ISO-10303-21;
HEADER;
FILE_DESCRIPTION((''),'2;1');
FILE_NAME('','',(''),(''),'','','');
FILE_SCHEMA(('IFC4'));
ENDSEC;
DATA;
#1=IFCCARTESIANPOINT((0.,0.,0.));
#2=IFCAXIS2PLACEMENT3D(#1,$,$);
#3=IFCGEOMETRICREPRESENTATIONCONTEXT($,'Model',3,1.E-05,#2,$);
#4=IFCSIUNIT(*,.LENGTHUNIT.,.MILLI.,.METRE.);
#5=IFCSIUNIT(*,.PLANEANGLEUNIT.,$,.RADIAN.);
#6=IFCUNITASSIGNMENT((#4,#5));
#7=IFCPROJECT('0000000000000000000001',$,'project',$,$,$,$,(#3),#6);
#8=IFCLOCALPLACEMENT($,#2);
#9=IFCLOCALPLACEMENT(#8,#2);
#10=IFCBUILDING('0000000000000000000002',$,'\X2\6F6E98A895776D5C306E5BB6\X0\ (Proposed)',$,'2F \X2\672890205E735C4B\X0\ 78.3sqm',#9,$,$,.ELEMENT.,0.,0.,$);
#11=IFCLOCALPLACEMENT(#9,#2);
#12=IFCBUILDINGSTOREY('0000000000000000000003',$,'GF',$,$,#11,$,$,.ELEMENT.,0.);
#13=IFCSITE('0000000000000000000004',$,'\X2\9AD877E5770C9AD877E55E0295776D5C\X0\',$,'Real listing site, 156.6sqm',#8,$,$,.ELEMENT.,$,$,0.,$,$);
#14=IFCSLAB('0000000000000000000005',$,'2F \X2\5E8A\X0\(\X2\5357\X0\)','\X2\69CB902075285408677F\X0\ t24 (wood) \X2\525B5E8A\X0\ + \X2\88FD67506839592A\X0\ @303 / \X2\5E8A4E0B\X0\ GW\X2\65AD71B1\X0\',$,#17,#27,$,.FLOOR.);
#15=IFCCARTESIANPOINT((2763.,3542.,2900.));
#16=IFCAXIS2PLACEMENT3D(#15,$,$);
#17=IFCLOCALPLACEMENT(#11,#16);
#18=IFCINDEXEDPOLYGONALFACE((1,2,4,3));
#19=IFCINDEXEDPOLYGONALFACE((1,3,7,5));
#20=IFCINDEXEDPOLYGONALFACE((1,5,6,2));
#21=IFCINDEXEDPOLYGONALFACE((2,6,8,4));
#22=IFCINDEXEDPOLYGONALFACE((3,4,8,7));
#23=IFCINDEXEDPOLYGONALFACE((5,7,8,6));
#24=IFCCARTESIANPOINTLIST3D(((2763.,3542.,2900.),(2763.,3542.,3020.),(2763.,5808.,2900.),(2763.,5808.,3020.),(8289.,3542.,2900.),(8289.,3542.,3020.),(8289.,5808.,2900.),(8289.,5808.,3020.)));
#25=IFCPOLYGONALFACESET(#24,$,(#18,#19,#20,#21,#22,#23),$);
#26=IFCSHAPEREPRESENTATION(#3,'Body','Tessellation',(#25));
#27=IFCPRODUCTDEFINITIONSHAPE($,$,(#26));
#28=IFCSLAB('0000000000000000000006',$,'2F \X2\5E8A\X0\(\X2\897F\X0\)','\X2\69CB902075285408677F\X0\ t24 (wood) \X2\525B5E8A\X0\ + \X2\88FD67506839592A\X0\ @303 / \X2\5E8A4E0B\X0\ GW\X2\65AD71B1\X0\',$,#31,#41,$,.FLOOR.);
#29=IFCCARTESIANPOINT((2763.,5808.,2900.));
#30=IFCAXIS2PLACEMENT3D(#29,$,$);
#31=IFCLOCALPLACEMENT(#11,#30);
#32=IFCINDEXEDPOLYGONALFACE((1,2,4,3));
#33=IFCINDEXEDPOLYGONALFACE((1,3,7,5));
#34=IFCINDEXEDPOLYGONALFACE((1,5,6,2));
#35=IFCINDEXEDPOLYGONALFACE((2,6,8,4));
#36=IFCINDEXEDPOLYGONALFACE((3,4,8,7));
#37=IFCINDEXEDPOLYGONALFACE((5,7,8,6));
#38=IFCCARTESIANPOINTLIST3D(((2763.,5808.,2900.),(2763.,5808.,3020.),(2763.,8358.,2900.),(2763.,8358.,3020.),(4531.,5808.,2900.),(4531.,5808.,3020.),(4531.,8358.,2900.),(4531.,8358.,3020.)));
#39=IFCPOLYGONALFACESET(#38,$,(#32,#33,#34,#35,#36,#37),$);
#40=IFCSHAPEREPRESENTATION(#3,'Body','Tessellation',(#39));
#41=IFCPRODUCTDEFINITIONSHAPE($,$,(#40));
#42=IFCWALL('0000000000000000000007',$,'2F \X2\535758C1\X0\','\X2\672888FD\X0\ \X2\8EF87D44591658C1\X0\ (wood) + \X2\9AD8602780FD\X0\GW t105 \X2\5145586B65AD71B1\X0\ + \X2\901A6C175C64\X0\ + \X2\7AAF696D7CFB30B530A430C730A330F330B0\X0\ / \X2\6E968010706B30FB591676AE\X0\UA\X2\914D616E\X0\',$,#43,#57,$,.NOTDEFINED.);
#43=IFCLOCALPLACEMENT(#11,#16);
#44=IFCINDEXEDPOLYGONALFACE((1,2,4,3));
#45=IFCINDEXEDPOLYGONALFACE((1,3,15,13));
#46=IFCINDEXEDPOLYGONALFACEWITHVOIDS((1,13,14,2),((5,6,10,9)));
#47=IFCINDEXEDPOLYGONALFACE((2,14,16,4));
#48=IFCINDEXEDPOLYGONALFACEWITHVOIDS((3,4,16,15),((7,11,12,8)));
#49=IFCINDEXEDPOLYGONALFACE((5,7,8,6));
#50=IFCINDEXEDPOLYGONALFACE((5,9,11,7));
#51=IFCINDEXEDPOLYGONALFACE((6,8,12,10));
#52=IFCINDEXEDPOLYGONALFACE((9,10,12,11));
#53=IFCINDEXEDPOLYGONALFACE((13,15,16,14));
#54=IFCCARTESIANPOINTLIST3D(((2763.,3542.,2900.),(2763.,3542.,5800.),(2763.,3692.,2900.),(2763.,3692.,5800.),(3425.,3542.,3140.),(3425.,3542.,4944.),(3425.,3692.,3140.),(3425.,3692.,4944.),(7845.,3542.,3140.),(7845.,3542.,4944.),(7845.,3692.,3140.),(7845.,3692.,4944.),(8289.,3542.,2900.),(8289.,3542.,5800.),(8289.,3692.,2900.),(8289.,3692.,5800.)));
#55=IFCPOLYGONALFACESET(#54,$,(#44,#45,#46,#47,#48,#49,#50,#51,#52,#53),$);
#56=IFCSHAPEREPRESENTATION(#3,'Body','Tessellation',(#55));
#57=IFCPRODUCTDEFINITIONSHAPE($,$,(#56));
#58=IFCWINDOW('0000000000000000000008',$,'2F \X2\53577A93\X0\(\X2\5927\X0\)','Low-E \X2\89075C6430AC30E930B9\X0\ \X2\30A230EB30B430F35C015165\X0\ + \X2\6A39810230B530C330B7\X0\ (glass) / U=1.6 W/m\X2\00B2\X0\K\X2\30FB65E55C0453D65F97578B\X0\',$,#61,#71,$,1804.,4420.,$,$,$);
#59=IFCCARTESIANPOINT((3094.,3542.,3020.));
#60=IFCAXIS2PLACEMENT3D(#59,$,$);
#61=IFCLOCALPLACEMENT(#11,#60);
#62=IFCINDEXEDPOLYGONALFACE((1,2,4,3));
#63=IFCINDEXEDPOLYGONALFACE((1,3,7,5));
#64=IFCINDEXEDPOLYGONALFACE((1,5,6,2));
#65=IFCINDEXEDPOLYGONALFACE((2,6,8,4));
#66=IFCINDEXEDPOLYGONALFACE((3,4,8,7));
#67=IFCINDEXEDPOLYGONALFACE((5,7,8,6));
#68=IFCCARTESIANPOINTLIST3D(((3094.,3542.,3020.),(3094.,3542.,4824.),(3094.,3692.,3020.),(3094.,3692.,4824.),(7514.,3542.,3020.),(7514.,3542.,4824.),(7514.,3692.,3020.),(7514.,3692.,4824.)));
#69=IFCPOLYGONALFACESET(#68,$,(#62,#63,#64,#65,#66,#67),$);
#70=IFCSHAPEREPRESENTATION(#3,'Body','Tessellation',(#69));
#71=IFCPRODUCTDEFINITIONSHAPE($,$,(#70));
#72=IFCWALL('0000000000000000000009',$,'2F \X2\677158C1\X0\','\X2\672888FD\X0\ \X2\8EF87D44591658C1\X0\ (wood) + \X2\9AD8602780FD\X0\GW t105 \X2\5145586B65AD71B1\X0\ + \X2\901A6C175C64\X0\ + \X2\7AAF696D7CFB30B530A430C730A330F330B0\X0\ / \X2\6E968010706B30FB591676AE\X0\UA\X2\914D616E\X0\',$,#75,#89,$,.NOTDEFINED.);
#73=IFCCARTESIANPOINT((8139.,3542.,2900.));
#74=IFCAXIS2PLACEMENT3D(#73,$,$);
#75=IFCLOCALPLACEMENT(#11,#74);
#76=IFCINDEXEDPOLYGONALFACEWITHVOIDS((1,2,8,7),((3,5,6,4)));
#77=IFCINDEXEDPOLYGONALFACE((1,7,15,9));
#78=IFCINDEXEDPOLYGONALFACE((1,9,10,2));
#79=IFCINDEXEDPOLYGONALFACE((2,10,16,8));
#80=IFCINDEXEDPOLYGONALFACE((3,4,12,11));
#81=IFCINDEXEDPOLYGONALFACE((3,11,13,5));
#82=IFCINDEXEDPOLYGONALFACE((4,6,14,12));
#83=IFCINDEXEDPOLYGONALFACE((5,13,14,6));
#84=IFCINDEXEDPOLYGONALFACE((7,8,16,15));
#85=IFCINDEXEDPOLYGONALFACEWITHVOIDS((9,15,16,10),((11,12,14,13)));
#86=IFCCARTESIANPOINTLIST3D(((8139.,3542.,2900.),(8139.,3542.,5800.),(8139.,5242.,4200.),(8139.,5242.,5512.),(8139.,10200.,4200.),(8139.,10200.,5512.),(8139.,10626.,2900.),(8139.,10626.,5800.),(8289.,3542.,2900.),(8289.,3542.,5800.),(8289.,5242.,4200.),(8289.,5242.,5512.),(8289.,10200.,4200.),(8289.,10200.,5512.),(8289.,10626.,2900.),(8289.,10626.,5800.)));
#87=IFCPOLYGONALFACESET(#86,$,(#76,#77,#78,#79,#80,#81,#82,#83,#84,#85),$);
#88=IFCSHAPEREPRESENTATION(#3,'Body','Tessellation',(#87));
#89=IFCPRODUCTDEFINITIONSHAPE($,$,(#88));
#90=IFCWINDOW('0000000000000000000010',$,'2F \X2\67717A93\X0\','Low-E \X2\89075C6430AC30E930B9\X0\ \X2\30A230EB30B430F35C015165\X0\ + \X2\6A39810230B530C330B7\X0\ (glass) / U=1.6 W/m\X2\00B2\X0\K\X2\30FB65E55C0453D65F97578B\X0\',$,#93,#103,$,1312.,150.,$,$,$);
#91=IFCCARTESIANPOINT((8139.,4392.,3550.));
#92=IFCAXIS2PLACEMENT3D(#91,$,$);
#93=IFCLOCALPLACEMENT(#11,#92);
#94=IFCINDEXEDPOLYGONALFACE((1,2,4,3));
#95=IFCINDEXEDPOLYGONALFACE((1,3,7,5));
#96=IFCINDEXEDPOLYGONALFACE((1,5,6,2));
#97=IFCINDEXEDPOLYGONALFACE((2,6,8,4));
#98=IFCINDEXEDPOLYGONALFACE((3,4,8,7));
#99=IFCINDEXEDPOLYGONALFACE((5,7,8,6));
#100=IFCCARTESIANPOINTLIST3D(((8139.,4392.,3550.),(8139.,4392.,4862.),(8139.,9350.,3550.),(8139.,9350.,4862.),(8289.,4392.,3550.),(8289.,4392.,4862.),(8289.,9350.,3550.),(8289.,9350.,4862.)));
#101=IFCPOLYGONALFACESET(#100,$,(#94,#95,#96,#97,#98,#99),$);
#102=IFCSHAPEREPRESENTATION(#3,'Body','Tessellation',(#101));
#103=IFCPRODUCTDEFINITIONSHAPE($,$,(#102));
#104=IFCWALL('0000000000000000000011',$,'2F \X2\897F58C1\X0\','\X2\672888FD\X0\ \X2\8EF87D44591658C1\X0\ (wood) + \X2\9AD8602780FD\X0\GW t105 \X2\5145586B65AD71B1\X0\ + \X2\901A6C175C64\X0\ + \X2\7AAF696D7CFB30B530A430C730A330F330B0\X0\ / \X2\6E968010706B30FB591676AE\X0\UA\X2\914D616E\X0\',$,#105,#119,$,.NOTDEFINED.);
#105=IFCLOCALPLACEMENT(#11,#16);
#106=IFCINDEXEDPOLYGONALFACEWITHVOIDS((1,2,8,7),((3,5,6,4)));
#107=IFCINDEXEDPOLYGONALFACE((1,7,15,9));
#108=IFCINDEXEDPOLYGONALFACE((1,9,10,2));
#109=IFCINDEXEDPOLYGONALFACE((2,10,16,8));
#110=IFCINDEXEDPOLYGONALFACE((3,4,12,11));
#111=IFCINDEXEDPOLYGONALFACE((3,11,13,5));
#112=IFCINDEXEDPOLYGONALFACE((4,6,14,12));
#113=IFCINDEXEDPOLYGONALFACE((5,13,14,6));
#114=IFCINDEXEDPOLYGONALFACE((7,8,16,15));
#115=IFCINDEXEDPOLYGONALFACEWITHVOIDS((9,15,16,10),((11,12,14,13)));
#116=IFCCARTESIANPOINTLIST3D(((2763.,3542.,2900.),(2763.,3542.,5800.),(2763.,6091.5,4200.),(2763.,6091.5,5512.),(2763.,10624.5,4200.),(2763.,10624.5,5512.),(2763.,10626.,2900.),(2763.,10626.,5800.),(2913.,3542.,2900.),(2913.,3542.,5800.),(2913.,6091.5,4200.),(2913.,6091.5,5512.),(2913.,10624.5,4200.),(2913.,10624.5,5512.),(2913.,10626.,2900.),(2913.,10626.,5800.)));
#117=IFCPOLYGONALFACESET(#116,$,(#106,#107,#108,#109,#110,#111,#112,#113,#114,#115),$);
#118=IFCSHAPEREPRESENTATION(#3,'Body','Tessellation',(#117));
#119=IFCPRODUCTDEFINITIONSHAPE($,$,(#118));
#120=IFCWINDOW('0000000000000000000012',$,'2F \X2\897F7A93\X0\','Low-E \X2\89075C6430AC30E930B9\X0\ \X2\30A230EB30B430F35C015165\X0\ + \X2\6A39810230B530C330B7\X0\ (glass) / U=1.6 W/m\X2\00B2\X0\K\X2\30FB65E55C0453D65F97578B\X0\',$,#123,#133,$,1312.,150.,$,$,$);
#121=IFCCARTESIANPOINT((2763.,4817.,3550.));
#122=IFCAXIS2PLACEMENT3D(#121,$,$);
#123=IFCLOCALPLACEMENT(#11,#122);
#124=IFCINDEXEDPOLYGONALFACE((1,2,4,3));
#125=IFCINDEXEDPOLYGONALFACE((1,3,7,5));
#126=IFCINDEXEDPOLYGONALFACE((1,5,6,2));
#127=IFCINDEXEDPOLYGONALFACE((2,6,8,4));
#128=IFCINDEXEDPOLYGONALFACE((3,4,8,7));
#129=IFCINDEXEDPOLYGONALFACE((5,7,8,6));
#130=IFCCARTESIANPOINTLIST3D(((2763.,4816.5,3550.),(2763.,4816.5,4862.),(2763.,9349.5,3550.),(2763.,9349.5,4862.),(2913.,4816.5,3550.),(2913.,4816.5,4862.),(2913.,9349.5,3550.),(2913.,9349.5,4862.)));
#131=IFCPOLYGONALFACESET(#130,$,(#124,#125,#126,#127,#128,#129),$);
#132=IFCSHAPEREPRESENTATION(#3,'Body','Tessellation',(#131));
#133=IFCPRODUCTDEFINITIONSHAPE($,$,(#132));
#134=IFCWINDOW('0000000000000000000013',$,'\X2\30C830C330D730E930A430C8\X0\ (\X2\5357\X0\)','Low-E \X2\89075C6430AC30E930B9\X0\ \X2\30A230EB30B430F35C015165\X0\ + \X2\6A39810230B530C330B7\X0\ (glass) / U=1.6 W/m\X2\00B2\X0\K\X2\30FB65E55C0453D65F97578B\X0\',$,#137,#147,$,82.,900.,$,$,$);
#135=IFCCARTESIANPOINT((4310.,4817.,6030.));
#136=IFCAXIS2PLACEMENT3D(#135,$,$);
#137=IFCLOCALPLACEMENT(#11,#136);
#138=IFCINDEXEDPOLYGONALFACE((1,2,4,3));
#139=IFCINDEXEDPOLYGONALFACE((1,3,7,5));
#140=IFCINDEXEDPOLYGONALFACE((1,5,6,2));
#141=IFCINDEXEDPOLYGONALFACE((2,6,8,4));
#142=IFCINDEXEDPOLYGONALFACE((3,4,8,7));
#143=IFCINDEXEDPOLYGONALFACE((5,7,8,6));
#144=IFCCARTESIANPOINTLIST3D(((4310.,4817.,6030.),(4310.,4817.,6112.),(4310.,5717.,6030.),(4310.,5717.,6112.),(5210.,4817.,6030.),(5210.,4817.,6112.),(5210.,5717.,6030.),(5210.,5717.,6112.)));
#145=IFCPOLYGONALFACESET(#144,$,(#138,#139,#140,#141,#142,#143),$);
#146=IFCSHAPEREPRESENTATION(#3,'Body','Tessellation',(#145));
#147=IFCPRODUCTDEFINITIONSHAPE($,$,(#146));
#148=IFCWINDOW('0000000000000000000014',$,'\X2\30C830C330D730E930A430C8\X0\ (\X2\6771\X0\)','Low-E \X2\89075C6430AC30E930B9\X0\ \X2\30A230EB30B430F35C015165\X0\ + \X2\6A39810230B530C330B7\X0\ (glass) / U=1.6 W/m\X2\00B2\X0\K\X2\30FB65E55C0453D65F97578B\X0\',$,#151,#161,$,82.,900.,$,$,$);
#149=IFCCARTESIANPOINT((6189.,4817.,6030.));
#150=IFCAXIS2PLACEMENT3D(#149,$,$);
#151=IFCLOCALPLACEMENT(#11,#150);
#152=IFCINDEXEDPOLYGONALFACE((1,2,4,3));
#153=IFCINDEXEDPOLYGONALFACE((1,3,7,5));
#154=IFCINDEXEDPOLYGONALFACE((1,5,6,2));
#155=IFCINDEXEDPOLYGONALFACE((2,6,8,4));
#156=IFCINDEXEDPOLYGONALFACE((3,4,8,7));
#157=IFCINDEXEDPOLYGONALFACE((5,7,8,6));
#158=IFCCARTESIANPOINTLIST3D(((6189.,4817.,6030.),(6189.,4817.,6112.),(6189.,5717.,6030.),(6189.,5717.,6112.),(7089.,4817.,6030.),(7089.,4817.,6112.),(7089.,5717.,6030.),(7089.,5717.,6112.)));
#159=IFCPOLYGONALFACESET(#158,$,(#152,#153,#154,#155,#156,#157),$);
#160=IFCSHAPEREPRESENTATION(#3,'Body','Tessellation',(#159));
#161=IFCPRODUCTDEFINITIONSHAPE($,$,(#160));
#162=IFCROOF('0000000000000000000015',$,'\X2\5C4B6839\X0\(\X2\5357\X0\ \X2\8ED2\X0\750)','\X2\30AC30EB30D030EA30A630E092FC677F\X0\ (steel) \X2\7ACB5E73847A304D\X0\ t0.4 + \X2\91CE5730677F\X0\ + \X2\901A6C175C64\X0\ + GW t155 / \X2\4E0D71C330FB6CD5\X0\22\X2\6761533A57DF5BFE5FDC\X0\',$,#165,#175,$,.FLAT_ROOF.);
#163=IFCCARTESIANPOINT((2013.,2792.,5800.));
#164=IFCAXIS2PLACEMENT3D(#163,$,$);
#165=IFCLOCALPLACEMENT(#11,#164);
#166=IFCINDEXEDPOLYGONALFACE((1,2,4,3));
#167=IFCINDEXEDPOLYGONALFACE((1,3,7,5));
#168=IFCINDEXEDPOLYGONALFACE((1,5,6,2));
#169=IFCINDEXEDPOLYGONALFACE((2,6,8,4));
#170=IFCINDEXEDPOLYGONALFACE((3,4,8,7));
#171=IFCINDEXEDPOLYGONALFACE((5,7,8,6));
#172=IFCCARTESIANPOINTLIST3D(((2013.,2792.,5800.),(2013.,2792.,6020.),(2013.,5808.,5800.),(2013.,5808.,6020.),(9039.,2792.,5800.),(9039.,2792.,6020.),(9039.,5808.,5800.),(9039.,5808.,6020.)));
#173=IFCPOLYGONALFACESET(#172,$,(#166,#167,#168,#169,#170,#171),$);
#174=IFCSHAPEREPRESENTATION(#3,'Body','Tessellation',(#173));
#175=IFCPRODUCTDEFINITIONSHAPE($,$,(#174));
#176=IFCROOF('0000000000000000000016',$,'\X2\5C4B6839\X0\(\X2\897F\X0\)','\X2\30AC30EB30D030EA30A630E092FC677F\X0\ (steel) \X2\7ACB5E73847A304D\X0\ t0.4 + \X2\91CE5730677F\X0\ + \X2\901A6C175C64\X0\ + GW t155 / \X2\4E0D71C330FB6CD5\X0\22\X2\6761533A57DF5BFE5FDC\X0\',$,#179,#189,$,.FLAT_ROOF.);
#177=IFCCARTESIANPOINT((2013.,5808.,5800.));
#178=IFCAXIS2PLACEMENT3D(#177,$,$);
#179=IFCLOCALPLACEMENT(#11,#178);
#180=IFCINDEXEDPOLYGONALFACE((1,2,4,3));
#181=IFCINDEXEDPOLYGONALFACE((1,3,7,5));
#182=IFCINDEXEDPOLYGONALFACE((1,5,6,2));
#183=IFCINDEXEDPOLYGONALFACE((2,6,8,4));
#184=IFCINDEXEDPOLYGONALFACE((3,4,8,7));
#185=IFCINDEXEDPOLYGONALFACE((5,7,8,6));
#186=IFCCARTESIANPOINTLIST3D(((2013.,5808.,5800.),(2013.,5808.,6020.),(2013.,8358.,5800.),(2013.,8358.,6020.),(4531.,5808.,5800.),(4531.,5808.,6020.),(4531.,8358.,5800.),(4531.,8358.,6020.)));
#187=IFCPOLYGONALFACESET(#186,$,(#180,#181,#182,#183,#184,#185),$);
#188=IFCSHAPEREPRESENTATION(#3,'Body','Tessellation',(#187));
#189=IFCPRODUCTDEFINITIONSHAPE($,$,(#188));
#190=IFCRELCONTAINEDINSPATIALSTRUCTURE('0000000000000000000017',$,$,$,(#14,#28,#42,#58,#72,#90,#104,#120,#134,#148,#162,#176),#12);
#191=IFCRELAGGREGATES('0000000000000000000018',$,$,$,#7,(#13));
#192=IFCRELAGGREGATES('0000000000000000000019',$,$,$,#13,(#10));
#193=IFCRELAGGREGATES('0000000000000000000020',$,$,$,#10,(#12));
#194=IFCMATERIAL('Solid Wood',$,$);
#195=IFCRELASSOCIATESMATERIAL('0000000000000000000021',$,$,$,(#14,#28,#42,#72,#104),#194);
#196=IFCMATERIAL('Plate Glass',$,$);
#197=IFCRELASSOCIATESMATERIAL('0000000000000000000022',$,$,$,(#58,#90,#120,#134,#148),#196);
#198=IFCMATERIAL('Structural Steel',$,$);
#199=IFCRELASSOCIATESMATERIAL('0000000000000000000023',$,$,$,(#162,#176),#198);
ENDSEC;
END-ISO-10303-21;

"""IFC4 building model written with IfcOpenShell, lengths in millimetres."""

from ifc_helpers import new_model, si_unit, frame, frame_2d, origin, place, context, project, spatial, rectangle, extrude, material, element, fill, save


model = new_model("IFC4")

# Units and contexts
model_context = context("Model", 3, precision=1e-05, world=origin())
ifc_project = project(units=[si_unit("LENGTHUNIT", "METRE", prefix="MILLI"), si_unit("PLANEANGLEUNIT", "RADIAN")], contexts=[model_context])

# Site, building, storey
site_placement = place(None, origin())
site = spatial("IfcSite", under=ifc_project, at=site_placement, Name="高知県高知市長浜", ObjectType="Real listing site, 156.6sqm", CompositionType="ELEMENT", RefElevation=0.0)
building_placement = place(site_placement, origin())
building = spatial("IfcBuilding", under=site, at=building_placement, Name="潮風長浜の家 (Proposed)", ObjectType="2F 木造平屋 78.3sqm", CompositionType="ELEMENT", ElevationOfRefHeight=0.0, ElevationOfTerrain=0.0)
storey_placement = place(building_placement, origin())
storey = spatial("IfcBuildingStorey", under=building, at=storey_placement, Name="GF", CompositionType="ELEMENT", Elevation=0.0)

# Slabs
ifc_material_1 = material(Name="Solid Wood")
slab_1_placement = place(storey_placement, frame((2763.0, 3542.0, 2900.0)))
element("IfcSlab", 1, at=slab_1_placement, inside=storey, material=ifc_material_1, Name="2F 床(南)", Description="構造用合板 t24 (wood) 剛床 + 製材根太 @303 / 床下 GW断熱", PredefinedType="FLOOR", context=model_context, shape_type="SweptSolid", body=[
    extrude(rectangle(XDim=5526.0, YDim=2266.0, at=frame_2d((2763.0, 1133.0))), frame((2763.0, 3542.0, 2900.0)), (0.0, 0.0, 1.0), 120.0),
])
slab_2_placement = place(storey_placement, frame((2763.0, 5808.0, 2900.0)))
element("IfcSlab", 2, at=slab_2_placement, inside=storey, material=ifc_material_1, Name="2F 床(西)", Description="構造用合板 t24 (wood) 剛床 + 製材根太 @303 / 床下 GW断熱", PredefinedType="FLOOR", context=model_context, shape_type="SweptSolid", body=[
    extrude(rectangle(XDim=1768.0, YDim=2550.0, at=frame_2d((884.0, 1275.0))), frame((2763.0, 5808.0, 2900.0)), (0.0, 0.0, 1.0), 120.0),
])

# Walls, openings, windows
wall_1_placement = place(storey_placement, frame((2763.0, 3542.0, 2900.0)))
wall_1 = element("IfcWall", 3, at=wall_1_placement, inside=storey, material=ifc_material_1, Name="2F 南壁", Description="木製 軸組外壁 (wood) + 高性能GW t105 充填断熱 + 通気層 + 窯業系サイディング / 準耐火・外皮UA配慮", PredefinedType="NOTDEFINED", context=model_context, shape_type="SweptSolid", body=[
    extrude(rectangle(XDim=5526.0, YDim=150.0, at=frame_2d((2763.0, 75.0))), frame((2763.0, 3542.0, 2900.0)), (0.0, 0.0, 1.0), 2900.0),
])
opening_1_placement = place(storey_placement, frame((3094.0, 3542.0, 3020.0)))
opening_1 = element("IfcOpeningElement", 4, at=opening_1_placement, cuts=wall_1, PredefinedType="NOTDEFINED", context=model_context, shape_type="SweptSolid", body=[
    extrude(rectangle(XDim=4420.0, YDim=150.0, at=frame_2d((2210.0, 75.0))), frame((3094.0, 3542.0, 3020.0)), (0.0, 0.0, 1.0), 1804.0),
])
ifc_material_2 = material(Name="Plate Glass")
window_1_placement = place(storey_placement, frame((3094.0, 3542.0, 3020.0)))
window_1 = element("IfcWindow", 5, at=window_1_placement, inside=storey, material=ifc_material_2, Name="2F 南窓(大)", Description="Low-E 複層ガラス アルゴン封入 + 樹脂サッシ (glass) / U=1.6 W/m²K・日射取得型", OverallHeight=1804.0, OverallWidth=4420.0, context=model_context, shape_type="SweptSolid", body=[
    extrude(rectangle(XDim=4420.0, YDim=150.0, at=frame_2d((2210.0, 75.0))), frame((3094.0, 3542.0, 3020.0)), (0.0, 0.0, 1.0), 1804.0),
])
fill(opening_1, window_1)
wall_2_placement = place(storey_placement, frame((8139.0, 3542.0, 2900.0)))
wall_2 = element("IfcWall", 6, at=wall_2_placement, inside=storey, material=ifc_material_1, Name="2F 東壁", Description="木製 軸組外壁 (wood) + 高性能GW t105 充填断熱 + 通気層 + 窯業系サイディング / 準耐火・外皮UA配慮", PredefinedType="NOTDEFINED", context=model_context, shape_type="SweptSolid", body=[
    extrude(rectangle(XDim=150.0, YDim=7084.0, at=frame_2d((75.0, 3542.0))), frame((8139.0, 3542.0, 2900.0)), (0.0, 0.0, 1.0), 2900.0),
])
opening_2_placement = place(storey_placement, frame((8139.0, 4392.0, 3550.0)))
opening_2 = element("IfcOpeningElement", 7, at=opening_2_placement, cuts=wall_2, PredefinedType="NOTDEFINED", context=model_context, shape_type="SweptSolid", body=[
    extrude(rectangle(XDim=150.0, YDim=4958.0, at=frame_2d((75.0, 2479.0))), frame((8139.0, 4392.0, 3550.0)), (0.0, 0.0, 1.0), 1312.0),
])
window_2_placement = place(storey_placement, frame((8139.0, 4392.0, 3550.0)))
window_2 = element("IfcWindow", 8, at=window_2_placement, inside=storey, material=ifc_material_2, Name="2F 東窓", Description="Low-E 複層ガラス アルゴン封入 + 樹脂サッシ (glass) / U=1.6 W/m²K・日射取得型", OverallHeight=1312.0, OverallWidth=150.0, context=model_context, shape_type="SweptSolid", body=[
    extrude(rectangle(XDim=150.0, YDim=4958.0, at=frame_2d((75.0, 2479.0))), frame((8139.0, 4392.0, 3550.0)), (0.0, 0.0, 1.0), 1312.0),
])
fill(opening_2, window_2)
wall_3_placement = place(storey_placement, frame((2763.0, 3542.0, 2900.0)))
wall_3 = element("IfcWall", 9, at=wall_3_placement, inside=storey, material=ifc_material_1, Name="2F 西壁", Description="木製 軸組外壁 (wood) + 高性能GW t105 充填断熱 + 通気層 + 窯業系サイディング / 準耐火・外皮UA配慮", PredefinedType="NOTDEFINED", context=model_context, shape_type="SweptSolid", body=[
    extrude(rectangle(XDim=150.0, YDim=7084.0, at=frame_2d((75.0, 3542.0))), frame((2763.0, 3542.0, 2900.0)), (0.0, 0.0, 1.0), 2900.0),
])
opening_3_placement = place(storey_placement, frame((2763.0, 4817.0, 3550.0)))
opening_3 = element("IfcOpeningElement", 10, at=opening_3_placement, cuts=wall_3, PredefinedType="NOTDEFINED", context=model_context, shape_type="SweptSolid", body=[
    extrude(rectangle(XDim=150.0, YDim=4533.0, at=frame_2d((75.0, 2266.0))), frame((2763.0, 4817.0, 3550.0)), (0.0, 0.0, 1.0), 1312.0),
])
window_3_placement = place(storey_placement, frame((2763.0, 4817.0, 3550.0)))
window_3 = element("IfcWindow", 11, at=window_3_placement, inside=storey, material=ifc_material_2, Name="2F 西窓", Description="Low-E 複層ガラス アルゴン封入 + 樹脂サッシ (glass) / U=1.6 W/m²K・日射取得型", OverallHeight=1312.0, OverallWidth=150.0, context=model_context, shape_type="SweptSolid", body=[
    extrude(rectangle(XDim=150.0, YDim=4533.0, at=frame_2d((75.0, 2266.0))), frame((2763.0, 4817.0, 3550.0)), (0.0, 0.0, 1.0), 1312.0),
])
fill(opening_3, window_3)

# Windows
window_4_placement = place(storey_placement, frame((4310.0, 4817.0, 6030.0)))
element("IfcWindow", 12, at=window_4_placement, inside=storey, material=ifc_material_2, Name="トップライト (南)", Description="Low-E 複層ガラス アルゴン封入 + 樹脂サッシ (glass) / U=1.6 W/m²K・日射取得型", OverallHeight=82.0, OverallWidth=900.0, context=model_context, shape_type="SweptSolid", body=[
    extrude(rectangle(XDim=900.0, YDim=900.0, at=frame_2d((450.0, 450.0))), frame((4310.0, 4817.0, 6030.0)), (0.0, 0.0, 1.0), 82.0),
])
window_5_placement = place(storey_placement, frame((6189.0, 4817.0, 6030.0)))
element("IfcWindow", 13, at=window_5_placement, inside=storey, material=ifc_material_2, Name="トップライト (東)", Description="Low-E 複層ガラス アルゴン封入 + 樹脂サッシ (glass) / U=1.6 W/m²K・日射取得型", OverallHeight=82.0, OverallWidth=900.0, context=model_context, shape_type="SweptSolid", body=[
    extrude(rectangle(XDim=900.0, YDim=900.0, at=frame_2d((450.0, 450.0))), frame((6189.0, 4817.0, 6030.0)), (0.0, 0.0, 1.0), 82.0),
])

# Roofs
ifc_material_3 = material(Name="Structural Steel")
roof_1_placement = place(storey_placement, frame((2013.0, 2792.0, 5800.0)))
element("IfcRoof", 14, at=roof_1_placement, inside=storey, material=ifc_material_3, Name="屋根(南 軒750)", Description="ガルバリウム鋼板 (steel) 立平葺き t0.4 + 野地板 + 通気層 + GW t155 / 不燃・法22条区域対応", PredefinedType="FLAT_ROOF", context=model_context, shape_type="SweptSolid", body=[
    extrude(rectangle(XDim=7026.0, YDim=3016.0, at=frame_2d((3513.0, 1508.0))), frame((2013.0, 2792.0, 5800.0)), (0.0, 0.0, 1.0), 220.0),
])
roof_2_placement = place(storey_placement, frame((2013.0, 5808.0, 5800.0)))
element("IfcRoof", 15, at=roof_2_placement, inside=storey, material=ifc_material_3, Name="屋根(西)", Description="ガルバリウム鋼板 (steel) 立平葺き t0.4 + 野地板 + 通気層 + GW t155 / 不燃・法22条区域対応", PredefinedType="FLAT_ROOF", context=model_context, shape_type="SweptSolid", body=[
    extrude(rectangle(XDim=2518.0, YDim=2550.0, at=frame_2d((1259.0, 1275.0))), frame((2013.0, 5808.0, 5800.0)), (0.0, 0.0, 1.0), 220.0),
])

save(model, "model.ifc")
